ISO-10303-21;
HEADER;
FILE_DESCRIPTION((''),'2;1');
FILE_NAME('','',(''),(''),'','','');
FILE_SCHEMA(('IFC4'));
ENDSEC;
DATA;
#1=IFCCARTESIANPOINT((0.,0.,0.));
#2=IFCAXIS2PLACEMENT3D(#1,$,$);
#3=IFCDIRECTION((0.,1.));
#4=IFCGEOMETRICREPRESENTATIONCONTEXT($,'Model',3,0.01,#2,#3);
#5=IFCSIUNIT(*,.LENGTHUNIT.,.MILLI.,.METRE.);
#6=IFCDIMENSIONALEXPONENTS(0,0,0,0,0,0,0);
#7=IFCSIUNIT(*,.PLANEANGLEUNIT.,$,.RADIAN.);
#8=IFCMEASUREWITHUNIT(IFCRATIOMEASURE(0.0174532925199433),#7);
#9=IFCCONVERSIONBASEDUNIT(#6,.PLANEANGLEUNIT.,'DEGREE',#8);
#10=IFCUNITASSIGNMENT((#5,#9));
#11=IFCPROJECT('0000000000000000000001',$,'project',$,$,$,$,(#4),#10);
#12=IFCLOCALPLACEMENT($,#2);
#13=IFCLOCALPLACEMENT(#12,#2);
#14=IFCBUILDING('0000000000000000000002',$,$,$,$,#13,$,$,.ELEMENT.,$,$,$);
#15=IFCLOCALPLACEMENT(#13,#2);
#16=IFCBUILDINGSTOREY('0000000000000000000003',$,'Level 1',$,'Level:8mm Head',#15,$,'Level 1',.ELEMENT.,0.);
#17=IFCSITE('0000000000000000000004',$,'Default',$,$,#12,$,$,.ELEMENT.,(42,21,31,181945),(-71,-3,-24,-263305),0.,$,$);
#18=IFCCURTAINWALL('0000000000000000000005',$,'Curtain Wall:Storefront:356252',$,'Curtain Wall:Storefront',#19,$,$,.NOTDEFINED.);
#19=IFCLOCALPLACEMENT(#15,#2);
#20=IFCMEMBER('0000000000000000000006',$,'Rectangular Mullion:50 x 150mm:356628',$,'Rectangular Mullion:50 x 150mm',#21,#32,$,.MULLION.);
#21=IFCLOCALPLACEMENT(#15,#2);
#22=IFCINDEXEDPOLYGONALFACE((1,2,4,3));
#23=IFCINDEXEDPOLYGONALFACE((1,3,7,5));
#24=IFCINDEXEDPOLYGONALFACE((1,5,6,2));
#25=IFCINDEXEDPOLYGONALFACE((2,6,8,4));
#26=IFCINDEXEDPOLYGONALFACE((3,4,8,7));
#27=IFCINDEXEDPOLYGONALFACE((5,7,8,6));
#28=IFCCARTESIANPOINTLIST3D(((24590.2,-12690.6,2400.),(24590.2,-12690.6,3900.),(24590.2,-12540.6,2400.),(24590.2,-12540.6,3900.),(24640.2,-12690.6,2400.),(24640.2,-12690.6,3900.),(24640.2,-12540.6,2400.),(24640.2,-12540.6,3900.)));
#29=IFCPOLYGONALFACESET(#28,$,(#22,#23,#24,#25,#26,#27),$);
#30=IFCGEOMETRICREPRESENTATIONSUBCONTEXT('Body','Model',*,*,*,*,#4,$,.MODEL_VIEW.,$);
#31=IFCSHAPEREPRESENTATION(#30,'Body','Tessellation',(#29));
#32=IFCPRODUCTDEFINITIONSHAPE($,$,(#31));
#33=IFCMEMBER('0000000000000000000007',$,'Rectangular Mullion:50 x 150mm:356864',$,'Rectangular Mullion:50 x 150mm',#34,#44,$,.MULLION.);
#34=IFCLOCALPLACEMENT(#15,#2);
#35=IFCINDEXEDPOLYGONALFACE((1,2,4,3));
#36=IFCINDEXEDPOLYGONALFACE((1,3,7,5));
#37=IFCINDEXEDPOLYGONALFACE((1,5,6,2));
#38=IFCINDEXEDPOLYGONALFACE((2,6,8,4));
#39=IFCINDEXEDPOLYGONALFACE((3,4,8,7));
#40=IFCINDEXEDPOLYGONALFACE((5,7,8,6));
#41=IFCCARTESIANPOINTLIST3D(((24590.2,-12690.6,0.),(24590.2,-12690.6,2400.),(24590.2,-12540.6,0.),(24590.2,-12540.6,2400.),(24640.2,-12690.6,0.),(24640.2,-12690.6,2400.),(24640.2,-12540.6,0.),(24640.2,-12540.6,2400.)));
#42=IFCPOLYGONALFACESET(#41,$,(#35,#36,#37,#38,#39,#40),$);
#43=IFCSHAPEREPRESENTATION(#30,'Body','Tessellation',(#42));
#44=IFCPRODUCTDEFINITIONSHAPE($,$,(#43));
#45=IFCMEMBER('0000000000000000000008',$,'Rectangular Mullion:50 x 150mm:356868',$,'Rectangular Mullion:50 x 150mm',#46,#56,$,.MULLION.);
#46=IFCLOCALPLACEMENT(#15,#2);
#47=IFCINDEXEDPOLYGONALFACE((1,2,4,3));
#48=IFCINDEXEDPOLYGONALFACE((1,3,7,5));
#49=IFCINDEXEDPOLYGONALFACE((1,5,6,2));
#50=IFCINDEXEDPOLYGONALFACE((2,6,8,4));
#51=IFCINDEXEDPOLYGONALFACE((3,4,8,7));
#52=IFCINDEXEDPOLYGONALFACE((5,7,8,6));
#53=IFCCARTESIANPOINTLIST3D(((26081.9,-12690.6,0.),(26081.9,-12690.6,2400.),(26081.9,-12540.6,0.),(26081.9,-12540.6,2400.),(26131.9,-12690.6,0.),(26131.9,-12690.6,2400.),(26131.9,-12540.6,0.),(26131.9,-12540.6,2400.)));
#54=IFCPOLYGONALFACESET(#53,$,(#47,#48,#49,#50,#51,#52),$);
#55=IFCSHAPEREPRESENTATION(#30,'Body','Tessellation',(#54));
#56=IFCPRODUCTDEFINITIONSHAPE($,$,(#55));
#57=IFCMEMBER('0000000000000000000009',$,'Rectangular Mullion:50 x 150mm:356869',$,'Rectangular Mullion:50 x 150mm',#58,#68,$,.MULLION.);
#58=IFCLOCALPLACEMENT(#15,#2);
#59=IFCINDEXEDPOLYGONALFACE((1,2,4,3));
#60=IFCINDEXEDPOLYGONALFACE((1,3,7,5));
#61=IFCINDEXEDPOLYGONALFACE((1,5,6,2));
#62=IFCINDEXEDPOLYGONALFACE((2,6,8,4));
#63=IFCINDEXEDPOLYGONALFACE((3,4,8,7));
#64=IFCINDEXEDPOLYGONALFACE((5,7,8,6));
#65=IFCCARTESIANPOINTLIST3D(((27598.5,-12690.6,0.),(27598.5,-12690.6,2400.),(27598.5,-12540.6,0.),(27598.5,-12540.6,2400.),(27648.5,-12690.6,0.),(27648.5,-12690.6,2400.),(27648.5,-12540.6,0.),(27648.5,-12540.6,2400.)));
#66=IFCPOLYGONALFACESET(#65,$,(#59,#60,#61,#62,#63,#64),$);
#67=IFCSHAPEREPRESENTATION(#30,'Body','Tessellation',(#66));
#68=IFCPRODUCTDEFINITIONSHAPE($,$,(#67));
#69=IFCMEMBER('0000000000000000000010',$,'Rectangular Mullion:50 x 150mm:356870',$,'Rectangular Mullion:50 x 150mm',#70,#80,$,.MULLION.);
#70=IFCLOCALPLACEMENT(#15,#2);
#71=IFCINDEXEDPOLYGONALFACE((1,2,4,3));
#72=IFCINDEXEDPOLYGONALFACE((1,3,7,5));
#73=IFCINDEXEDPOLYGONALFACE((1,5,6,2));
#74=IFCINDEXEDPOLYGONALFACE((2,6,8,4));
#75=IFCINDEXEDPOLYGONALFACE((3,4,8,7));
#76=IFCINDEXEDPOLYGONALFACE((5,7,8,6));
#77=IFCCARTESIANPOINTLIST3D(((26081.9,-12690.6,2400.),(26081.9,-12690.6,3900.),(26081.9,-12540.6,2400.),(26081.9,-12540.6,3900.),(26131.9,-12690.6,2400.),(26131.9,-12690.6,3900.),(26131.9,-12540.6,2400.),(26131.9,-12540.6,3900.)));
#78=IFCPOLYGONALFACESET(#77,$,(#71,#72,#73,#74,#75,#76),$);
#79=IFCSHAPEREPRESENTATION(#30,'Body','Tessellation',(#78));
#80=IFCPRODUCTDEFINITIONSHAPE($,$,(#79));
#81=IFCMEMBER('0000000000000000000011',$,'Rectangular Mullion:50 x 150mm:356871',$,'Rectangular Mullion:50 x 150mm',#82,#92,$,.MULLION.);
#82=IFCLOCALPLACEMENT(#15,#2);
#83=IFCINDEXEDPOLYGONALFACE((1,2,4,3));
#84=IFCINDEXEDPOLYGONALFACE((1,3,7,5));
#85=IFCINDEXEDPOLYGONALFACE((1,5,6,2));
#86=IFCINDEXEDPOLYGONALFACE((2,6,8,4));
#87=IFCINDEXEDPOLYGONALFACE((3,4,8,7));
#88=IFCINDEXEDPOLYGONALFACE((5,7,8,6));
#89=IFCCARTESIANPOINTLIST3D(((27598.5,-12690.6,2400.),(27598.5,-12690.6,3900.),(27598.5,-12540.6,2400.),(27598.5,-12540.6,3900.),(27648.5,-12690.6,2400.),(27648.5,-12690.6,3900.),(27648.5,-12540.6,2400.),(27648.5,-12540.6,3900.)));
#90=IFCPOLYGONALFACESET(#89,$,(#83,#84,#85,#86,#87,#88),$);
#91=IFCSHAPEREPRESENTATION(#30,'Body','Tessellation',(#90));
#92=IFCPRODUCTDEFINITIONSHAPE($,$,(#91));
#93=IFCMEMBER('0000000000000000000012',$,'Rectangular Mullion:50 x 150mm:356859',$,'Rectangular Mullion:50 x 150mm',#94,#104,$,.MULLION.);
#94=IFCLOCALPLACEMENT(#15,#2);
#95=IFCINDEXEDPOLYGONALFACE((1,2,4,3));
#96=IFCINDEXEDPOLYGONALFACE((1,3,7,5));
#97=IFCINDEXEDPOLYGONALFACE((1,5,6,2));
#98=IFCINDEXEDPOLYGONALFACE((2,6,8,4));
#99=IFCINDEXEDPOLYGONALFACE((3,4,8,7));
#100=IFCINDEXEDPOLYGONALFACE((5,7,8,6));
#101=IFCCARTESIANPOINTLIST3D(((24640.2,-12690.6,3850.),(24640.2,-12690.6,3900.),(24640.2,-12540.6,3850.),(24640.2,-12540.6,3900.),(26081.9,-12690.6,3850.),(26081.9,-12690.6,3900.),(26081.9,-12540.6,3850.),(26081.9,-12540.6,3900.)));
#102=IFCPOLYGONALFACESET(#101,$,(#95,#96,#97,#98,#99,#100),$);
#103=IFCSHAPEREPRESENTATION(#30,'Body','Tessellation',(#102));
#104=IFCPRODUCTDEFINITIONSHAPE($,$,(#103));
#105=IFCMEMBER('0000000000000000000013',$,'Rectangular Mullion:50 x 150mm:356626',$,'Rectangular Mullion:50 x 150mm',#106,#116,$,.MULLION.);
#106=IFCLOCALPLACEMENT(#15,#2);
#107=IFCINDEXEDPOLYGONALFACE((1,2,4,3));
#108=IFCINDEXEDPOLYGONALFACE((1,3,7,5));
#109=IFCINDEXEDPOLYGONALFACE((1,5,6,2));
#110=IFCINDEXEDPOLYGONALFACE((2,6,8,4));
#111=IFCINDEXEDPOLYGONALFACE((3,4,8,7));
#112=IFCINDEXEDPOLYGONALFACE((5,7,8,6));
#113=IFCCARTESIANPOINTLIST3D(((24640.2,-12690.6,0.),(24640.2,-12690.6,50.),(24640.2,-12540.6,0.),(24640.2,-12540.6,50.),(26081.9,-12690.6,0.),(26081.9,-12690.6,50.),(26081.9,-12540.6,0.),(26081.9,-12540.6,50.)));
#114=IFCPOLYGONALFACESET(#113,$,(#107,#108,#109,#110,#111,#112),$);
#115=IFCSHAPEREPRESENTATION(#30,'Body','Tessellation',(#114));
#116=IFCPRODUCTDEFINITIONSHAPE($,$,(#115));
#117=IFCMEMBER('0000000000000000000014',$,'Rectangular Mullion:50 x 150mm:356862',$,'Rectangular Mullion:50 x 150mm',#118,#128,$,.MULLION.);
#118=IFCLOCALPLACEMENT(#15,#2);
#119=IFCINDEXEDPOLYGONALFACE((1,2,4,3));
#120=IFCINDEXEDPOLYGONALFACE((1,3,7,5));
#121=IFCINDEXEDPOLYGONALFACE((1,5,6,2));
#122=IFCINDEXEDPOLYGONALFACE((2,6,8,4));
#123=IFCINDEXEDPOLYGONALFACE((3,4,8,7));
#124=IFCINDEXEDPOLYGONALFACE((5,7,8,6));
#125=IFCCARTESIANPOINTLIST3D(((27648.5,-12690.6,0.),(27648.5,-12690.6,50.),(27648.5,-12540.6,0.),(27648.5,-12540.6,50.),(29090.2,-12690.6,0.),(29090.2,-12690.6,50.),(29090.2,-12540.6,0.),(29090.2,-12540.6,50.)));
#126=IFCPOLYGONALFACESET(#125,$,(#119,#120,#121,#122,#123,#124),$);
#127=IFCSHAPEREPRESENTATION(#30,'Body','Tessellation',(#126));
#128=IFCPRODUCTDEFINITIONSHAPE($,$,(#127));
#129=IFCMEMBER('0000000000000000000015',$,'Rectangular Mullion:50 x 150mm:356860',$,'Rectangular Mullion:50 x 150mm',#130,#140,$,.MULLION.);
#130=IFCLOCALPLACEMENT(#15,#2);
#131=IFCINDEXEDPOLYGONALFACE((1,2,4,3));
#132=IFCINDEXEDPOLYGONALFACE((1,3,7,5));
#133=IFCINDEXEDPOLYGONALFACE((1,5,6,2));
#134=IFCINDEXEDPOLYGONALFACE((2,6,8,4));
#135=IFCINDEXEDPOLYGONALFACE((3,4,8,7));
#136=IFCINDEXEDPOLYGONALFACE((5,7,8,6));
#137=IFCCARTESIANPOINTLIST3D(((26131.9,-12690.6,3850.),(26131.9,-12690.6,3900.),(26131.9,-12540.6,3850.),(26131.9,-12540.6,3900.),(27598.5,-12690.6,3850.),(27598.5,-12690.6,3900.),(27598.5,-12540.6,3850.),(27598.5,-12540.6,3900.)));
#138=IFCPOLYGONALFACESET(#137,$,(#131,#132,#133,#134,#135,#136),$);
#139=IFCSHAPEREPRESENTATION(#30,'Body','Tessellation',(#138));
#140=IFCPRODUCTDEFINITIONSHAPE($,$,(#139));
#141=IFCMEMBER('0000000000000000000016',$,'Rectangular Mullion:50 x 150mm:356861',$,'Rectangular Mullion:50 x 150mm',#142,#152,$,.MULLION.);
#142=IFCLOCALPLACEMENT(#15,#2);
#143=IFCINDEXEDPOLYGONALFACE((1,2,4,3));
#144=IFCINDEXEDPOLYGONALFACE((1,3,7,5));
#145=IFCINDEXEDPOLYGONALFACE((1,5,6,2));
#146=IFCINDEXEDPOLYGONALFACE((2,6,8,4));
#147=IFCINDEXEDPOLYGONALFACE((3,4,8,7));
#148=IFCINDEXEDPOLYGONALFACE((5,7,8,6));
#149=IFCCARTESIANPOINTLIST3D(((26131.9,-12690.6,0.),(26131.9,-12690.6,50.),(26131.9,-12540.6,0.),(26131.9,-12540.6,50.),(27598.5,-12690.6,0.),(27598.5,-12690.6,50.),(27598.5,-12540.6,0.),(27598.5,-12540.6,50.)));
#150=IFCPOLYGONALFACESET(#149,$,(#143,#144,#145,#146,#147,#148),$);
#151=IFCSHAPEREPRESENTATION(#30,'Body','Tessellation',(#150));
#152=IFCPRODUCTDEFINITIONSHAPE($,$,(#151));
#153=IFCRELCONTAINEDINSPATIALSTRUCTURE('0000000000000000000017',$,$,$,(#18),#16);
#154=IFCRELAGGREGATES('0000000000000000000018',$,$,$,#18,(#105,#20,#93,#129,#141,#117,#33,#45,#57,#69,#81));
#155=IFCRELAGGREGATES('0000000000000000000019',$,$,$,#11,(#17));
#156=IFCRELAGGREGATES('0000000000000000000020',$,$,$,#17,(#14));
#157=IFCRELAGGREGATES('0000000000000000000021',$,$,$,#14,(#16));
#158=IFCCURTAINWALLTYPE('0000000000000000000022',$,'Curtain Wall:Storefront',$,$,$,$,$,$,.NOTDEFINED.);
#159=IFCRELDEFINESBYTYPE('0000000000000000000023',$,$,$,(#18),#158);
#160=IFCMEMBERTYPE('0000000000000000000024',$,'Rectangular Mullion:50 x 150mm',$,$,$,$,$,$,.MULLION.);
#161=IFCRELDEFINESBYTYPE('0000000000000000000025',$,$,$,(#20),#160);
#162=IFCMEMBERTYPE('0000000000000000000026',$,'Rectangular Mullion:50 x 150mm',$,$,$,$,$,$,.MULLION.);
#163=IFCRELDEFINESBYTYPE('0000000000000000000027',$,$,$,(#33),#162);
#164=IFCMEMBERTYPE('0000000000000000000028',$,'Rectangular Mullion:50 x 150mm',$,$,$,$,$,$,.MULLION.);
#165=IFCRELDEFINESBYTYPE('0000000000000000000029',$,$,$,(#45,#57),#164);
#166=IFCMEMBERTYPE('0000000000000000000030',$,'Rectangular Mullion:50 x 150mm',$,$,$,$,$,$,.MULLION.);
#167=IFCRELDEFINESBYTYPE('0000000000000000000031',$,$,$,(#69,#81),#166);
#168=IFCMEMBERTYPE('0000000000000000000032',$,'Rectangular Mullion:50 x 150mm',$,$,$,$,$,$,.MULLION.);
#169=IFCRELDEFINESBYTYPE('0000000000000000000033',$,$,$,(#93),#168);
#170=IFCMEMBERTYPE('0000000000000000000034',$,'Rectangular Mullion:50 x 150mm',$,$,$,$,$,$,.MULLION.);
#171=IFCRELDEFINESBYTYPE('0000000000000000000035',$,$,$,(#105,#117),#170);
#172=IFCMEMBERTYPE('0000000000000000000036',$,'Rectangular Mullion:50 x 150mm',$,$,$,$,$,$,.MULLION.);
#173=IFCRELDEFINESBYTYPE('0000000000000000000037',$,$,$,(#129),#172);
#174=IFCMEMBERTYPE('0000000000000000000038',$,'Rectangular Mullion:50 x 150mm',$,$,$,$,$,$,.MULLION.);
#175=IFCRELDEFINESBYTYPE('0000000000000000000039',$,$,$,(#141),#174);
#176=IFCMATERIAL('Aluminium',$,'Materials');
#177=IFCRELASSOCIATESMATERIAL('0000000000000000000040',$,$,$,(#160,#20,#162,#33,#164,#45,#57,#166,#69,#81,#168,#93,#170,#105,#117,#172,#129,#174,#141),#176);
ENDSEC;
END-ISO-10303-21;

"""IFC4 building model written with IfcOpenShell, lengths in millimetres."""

from ifc_helpers import new_model, entity, si_unit, converted_unit, direction, frame, origin, place, context, subcontext, project, spatial, indexed_curve, outline, extrude, source, transform, mapped, material, type_object, type_shapes, element, aggregate, save


model = new_model("IFC4")

# Units and contexts
model_context = context("Model", 3, precision=0.01, world=origin(), true_north=direction((0.0, 1.0)))
body_context = subcontext(model_context, "Body", "Model", "MODEL_VIEW")
ifc_project = project(units=[si_unit("LENGTHUNIT", "METRE", prefix="MILLI"), converted_unit("PLANEANGLEUNIT", "DEGREE", entity("IfcRatioMeasure", 0.0174532925199433), si_unit("PLANEANGLEUNIT", "RADIAN"), dimensions=[0, 0, 0, 0, 0, 0, 0])], contexts=[model_context])

# Site, building, storey
site_placement = place(None, origin())
site = spatial("IfcSite", under=ifc_project, at=site_placement, Name="Default", CompositionType="ELEMENT", RefLatitude=(42, 21, 31, 181945), RefLongitude=(-71, -3, -24, -263305), RefElevation=0.0)
building_placement = place(site_placement, origin())
building = spatial("IfcBuilding", under=site, at=building_placement, CompositionType="ELEMENT")
storey_placement = place(building_placement, origin())
storey = spatial("IfcBuildingStorey", under=building, at=storey_placement, Name="Level 1", ObjectType="Level:8mm Head", LongName="Level 1", CompositionType="ELEMENT", Elevation=0.0)

# Curtain wall, members
curtain_wall_type_1 = type_object("IfcCurtainWallType", Name="Curtain Wall:Storefront", PredefinedType="NOTDEFINED")
curtain_wall_1_placement = place(storey_placement, origin())
curtain_wall_1 = element("IfcCurtainWall", 1, at=curtain_wall_1_placement, inside=storey, type_object=curtain_wall_type_1, Name="Curtain Wall:Storefront:356252", ObjectType="Curtain Wall:Storefront", PredefinedType="NOTDEFINED")
ifc_material_1 = material(Name="Aluminium", Category="Materials")
member_type_1 = type_object("IfcMemberType", Name="Rectangular Mullion:50 x 150mm", PredefinedType="MULLION", material=ifc_material_1)
shared_shape_1 = source(origin(), body_context, "Body", "SweptSolid", [
    extrude(outline(indexed_curve([(-75.0, -25.0), (75.0, -25.0), (75.0, 25.0), (-75.0, 25.0), (-75.0, -25.0)], self_intersect=False)), frame((-25.0, 0.0, -1500.0), z_axis=(0.0, 0.0, 1.0), x_axis=(0.0, -1.0, 0.0)), (0.0, 0.0, 1.0), 1500.0),
])
type_shapes(member_type_1, [shared_shape_1])
member_1_placement = place(storey_placement, frame((24590.2, -12615.6, 3900.0), z_axis=(0.0, 0.0, 1.0), x_axis=(-1.0, 0.0, 0.0)))
member_1 = element("IfcMember", 2, at=member_1_placement, type_object=member_type_1, material=ifc_material_1, Name="Rectangular Mullion:50 x 150mm:356628", ObjectType="Rectangular Mullion:50 x 150mm", PredefinedType="MULLION", context=body_context, shape_type="MappedRepresentation", body=[
    mapped(shared_shape_1, transform((0.0, 0.0, 0.0), scale=1.0)),
])
member_type_2 = type_object("IfcMemberType", Name="Rectangular Mullion:50 x 150mm", PredefinedType="MULLION", material=ifc_material_1)
shared_shape_2 = source(origin(), body_context, "Body", "SweptSolid", [
    extrude(outline(indexed_curve([(-75.0, -25.0), (75.0, -25.0), (75.0, 25.0), (-75.0, 25.0), (-75.0, -25.0)], self_intersect=False)), frame((-25.0, 0.0, -2400.0), z_axis=(0.0, 0.0, 1.0), x_axis=(0.0, -1.0, 0.0)), (0.0, 0.0, 1.0), 2400.0),
])
type_shapes(member_type_2, [shared_shape_2])
member_2_placement = place(storey_placement, frame((24590.2, -12615.6, 2400.0), z_axis=(0.0, 0.0, 1.0), x_axis=(-1.0, 0.0, 0.0)))
member_2 = element("IfcMember", 3, at=member_2_placement, type_object=member_type_2, material=ifc_material_1, Name="Rectangular Mullion:50 x 150mm:356864", ObjectType="Rectangular Mullion:50 x 150mm", PredefinedType="MULLION", context=body_context, shape_type="MappedRepresentation", body=[
    mapped(shared_shape_2, transform((0.0, 0.0, 0.0), scale=1.0)),
])
member_type_3 = type_object("IfcMemberType", Name="Rectangular Mullion:50 x 150mm", PredefinedType="MULLION", material=ifc_material_1)
shared_shape_3 = source(origin(), body_context, "Body", "SweptSolid", [
    extrude(outline(indexed_curve([(-75.0, -25.0), (75.0, -25.0), (75.0, 25.0), (-75.0, 25.0), (-75.0, -25.0)], self_intersect=False)), frame((0.0, 0.0, -2400.0), z_axis=(0.0, 0.0, 1.0), x_axis=(0.0, -1.0, 0.0)), (0.0, 0.0, 1.0), 2400.0),
])
type_shapes(member_type_3, [shared_shape_3])
member_3_placement = place(storey_placement, frame((26106.9, -12615.6, 0.0), z_axis=(0.0, 0.0, -1.0), x_axis=(1.0, 0.0, 0.0)))
member_3 = element("IfcMember", 4, at=member_3_placement, type_object=member_type_3, material=ifc_material_1, Name="Rectangular Mullion:50 x 150mm:356868", ObjectType="Rectangular Mullion:50 x 150mm", PredefinedType="MULLION", context=body_context, shape_type="MappedRepresentation", body=[
    mapped(shared_shape_3, transform((0.0, 0.0, 0.0), scale=1.0)),
])
member_4_placement = place(storey_placement, frame((27623.5, -12615.6, 0.0), z_axis=(0.0, 0.0, -1.0), x_axis=(1.0, 0.0, 0.0)))
member_4 = element("IfcMember", 5, at=member_4_placement, type_object=member_type_3, material=ifc_material_1, Name="Rectangular Mullion:50 x 150mm:356869", ObjectType="Rectangular Mullion:50 x 150mm", PredefinedType="MULLION", context=body_context, shape_type="MappedRepresentation", body=[
    mapped(shared_shape_3, transform((0.0, 0.0, 0.0), scale=1.0)),
])
member_type_4 = type_object("IfcMemberType", Name="Rectangular Mullion:50 x 150mm", PredefinedType="MULLION", material=ifc_material_1)
shared_shape_4 = source(origin(), body_context, "Body", "SweptSolid", [
    extrude(outline(indexed_curve([(-75.0, -25.0), (75.0, -25.0), (75.0, 25.0), (-75.0, 25.0), (-75.0, -25.0)], self_intersect=False)), frame((0.0, 0.0, -1500.0), z_axis=(0.0, 0.0, 1.0), x_axis=(0.0, -1.0, 0.0)), (0.0, 0.0, 1.0), 1500.0),
])
type_shapes(member_type_4, [shared_shape_4])
member_5_placement = place(storey_placement, frame((26106.9, -12615.6, 2400.0), z_axis=(0.0, 0.0, -1.0), x_axis=(1.0, 0.0, 0.0)))
member_5 = element("IfcMember", 6, at=member_5_placement, type_object=member_type_4, material=ifc_material_1, Name="Rectangular Mullion:50 x 150mm:356870", ObjectType="Rectangular Mullion:50 x 150mm", PredefinedType="MULLION", context=body_context, shape_type="MappedRepresentation", body=[
    mapped(shared_shape_4, transform((0.0, 0.0, 0.0), scale=1.0)),
])
member_6_placement = place(storey_placement, frame((27623.5, -12615.6, 2400.0), z_axis=(0.0, 0.0, -1.0), x_axis=(1.0, 0.0, 0.0)))
member_6 = element("IfcMember", 7, at=member_6_placement, type_object=member_type_4, material=ifc_material_1, Name="Rectangular Mullion:50 x 150mm:356871", ObjectType="Rectangular Mullion:50 x 150mm", PredefinedType="MULLION", context=body_context, shape_type="MappedRepresentation", body=[
    mapped(shared_shape_4, transform((0.0, 0.0, 0.0), scale=1.0)),
])
member_type_5 = type_object("IfcMemberType", Name="Rectangular Mullion:50 x 150mm", PredefinedType="MULLION", material=ifc_material_1)
shared_shape_5 = source(origin(), body_context, "Body", "SweptSolid", [
    extrude(outline(indexed_curve([(-75.0, -25.0), (75.0, -25.0), (75.0, 25.0), (-75.0, 25.0), (-75.0, -25.0)], self_intersect=False)), frame((-25.0, 0.0, -1441.7), z_axis=(0.0, 0.0, 1.0), x_axis=(0.0, -1.0, 0.0)), (0.0, 0.0, 1.0), 1441.7),
])
type_shapes(member_type_5, [shared_shape_5])
member_7_placement = place(storey_placement, frame((26081.9, -12615.6, 3900.0), z_axis=(1.0, 0.0, 0.0), x_axis=(0.0, 0.0, 1.0)))
member_7 = element("IfcMember", 8, at=member_7_placement, type_object=member_type_5, material=ifc_material_1, Name="Rectangular Mullion:50 x 150mm:356859", ObjectType="Rectangular Mullion:50 x 150mm", PredefinedType="MULLION", context=body_context, shape_type="MappedRepresentation", body=[
    mapped(shared_shape_5, transform((0.0, 0.0, 0.0), scale=1.0)),
])
member_type_6 = type_object("IfcMemberType", Name="Rectangular Mullion:50 x 150mm", PredefinedType="MULLION", material=ifc_material_1)
shared_shape_6 = source(origin(), body_context, "Body", "SweptSolid", [
    extrude(outline(indexed_curve([(-75.0, -25.0), (75.0, -25.0), (75.0, 25.0), (-75.0, 25.0), (-75.0, -25.0)], self_intersect=False)), frame((-25.0, 0.0, -1441.7), z_axis=(0.0, 0.0, 1.0), x_axis=(0.0, -1.0, 0.0)), (0.0, 0.0, 1.0), 1441.7),
])
type_shapes(member_type_6, [shared_shape_6])
member_8_placement = place(storey_placement, frame((24640.2, -12615.6, 0.0), z_axis=(-1.0, 0.0, 0.0), x_axis=(0.0, 0.0, -1.0)))
member_8 = element("IfcMember", 9, at=member_8_placement, type_object=member_type_6, material=ifc_material_1, Name="Rectangular Mullion:50 x 150mm:356626", ObjectType="Rectangular Mullion:50 x 150mm", PredefinedType="MULLION", context=body_context, shape_type="MappedRepresentation", body=[
    mapped(shared_shape_6, transform((0.0, 0.0, 0.0), scale=1.0)),
])
member_9_placement = place(storey_placement, frame((27648.5, -12615.6, 0.0), z_axis=(-1.0, 0.0, 0.0), x_axis=(0.0, 0.0, -1.0)))
member_9 = element("IfcMember", 10, at=member_9_placement, type_object=member_type_6, material=ifc_material_1, Name="Rectangular Mullion:50 x 150mm:356862", ObjectType="Rectangular Mullion:50 x 150mm", PredefinedType="MULLION", context=body_context, shape_type="MappedRepresentation", body=[
    mapped(shared_shape_6, transform((0.0, 0.0, 0.0), scale=1.0)),
])
member_type_7 = type_object("IfcMemberType", Name="Rectangular Mullion:50 x 150mm", PredefinedType="MULLION", material=ifc_material_1)
shared_shape_7 = source(origin(), body_context, "Body", "SweptSolid", [
    extrude(outline(indexed_curve([(-75.0, -25.0), (75.0, -25.0), (75.0, 25.0), (-75.0, 25.0), (-75.0, -25.0)], self_intersect=False)), frame((-25.0, 0.0, -1466.7), z_axis=(0.0, 0.0, 1.0), x_axis=(0.0, -1.0, 0.0)), (0.0, 0.0, 1.0), 1466.7),
])
type_shapes(member_type_7, [shared_shape_7])
member_10_placement = place(storey_placement, frame((27598.5, -12615.6, 3900.0), z_axis=(1.0, 0.0, 0.0), x_axis=(0.0, 0.0, 1.0)))
member_10 = element("IfcMember", 11, at=member_10_placement, type_object=member_type_7, material=ifc_material_1, Name="Rectangular Mullion:50 x 150mm:356860", ObjectType="Rectangular Mullion:50 x 150mm", PredefinedType="MULLION", context=body_context, shape_type="MappedRepresentation", body=[
    mapped(shared_shape_7, transform((0.0, 0.0, 0.0), scale=1.0)),
])
member_type_8 = type_object("IfcMemberType", Name="Rectangular Mullion:50 x 150mm", PredefinedType="MULLION", material=ifc_material_1)
shared_shape_8 = source(origin(), body_context, "Body", "SweptSolid", [
    extrude(outline(indexed_curve([(-75.0, -25.0), (75.0, -25.0), (75.0, 25.0), (-75.0, 25.0), (-75.0, -25.0)], self_intersect=False)), frame((-25.0, 0.0, -1466.7), z_axis=(0.0, 0.0, 1.0), x_axis=(0.0, -1.0, 0.0)), (0.0, 0.0, 1.0), 1466.7),
])
type_shapes(member_type_8, [shared_shape_8])
member_11_placement = place(storey_placement, frame((26131.9, -12615.6, 0.0), z_axis=(-1.0, 0.0, 0.0), x_axis=(0.0, 0.0, -1.0)))
member_11 = element("IfcMember", 12, at=member_11_placement, type_object=member_type_8, material=ifc_material_1, Name="Rectangular Mullion:50 x 150mm:356861", ObjectType="Rectangular Mullion:50 x 150mm", PredefinedType="MULLION", context=body_context, shape_type="MappedRepresentation", body=[
    mapped(shared_shape_8, transform((0.0, 0.0, 0.0), scale=1.0)),
])

aggregate(curtain_wall_1, [member_8, member_1, member_7, member_10, member_11, member_9, member_2, member_3, member_4, member_5, member_6])

save(model, "model.ifc")
